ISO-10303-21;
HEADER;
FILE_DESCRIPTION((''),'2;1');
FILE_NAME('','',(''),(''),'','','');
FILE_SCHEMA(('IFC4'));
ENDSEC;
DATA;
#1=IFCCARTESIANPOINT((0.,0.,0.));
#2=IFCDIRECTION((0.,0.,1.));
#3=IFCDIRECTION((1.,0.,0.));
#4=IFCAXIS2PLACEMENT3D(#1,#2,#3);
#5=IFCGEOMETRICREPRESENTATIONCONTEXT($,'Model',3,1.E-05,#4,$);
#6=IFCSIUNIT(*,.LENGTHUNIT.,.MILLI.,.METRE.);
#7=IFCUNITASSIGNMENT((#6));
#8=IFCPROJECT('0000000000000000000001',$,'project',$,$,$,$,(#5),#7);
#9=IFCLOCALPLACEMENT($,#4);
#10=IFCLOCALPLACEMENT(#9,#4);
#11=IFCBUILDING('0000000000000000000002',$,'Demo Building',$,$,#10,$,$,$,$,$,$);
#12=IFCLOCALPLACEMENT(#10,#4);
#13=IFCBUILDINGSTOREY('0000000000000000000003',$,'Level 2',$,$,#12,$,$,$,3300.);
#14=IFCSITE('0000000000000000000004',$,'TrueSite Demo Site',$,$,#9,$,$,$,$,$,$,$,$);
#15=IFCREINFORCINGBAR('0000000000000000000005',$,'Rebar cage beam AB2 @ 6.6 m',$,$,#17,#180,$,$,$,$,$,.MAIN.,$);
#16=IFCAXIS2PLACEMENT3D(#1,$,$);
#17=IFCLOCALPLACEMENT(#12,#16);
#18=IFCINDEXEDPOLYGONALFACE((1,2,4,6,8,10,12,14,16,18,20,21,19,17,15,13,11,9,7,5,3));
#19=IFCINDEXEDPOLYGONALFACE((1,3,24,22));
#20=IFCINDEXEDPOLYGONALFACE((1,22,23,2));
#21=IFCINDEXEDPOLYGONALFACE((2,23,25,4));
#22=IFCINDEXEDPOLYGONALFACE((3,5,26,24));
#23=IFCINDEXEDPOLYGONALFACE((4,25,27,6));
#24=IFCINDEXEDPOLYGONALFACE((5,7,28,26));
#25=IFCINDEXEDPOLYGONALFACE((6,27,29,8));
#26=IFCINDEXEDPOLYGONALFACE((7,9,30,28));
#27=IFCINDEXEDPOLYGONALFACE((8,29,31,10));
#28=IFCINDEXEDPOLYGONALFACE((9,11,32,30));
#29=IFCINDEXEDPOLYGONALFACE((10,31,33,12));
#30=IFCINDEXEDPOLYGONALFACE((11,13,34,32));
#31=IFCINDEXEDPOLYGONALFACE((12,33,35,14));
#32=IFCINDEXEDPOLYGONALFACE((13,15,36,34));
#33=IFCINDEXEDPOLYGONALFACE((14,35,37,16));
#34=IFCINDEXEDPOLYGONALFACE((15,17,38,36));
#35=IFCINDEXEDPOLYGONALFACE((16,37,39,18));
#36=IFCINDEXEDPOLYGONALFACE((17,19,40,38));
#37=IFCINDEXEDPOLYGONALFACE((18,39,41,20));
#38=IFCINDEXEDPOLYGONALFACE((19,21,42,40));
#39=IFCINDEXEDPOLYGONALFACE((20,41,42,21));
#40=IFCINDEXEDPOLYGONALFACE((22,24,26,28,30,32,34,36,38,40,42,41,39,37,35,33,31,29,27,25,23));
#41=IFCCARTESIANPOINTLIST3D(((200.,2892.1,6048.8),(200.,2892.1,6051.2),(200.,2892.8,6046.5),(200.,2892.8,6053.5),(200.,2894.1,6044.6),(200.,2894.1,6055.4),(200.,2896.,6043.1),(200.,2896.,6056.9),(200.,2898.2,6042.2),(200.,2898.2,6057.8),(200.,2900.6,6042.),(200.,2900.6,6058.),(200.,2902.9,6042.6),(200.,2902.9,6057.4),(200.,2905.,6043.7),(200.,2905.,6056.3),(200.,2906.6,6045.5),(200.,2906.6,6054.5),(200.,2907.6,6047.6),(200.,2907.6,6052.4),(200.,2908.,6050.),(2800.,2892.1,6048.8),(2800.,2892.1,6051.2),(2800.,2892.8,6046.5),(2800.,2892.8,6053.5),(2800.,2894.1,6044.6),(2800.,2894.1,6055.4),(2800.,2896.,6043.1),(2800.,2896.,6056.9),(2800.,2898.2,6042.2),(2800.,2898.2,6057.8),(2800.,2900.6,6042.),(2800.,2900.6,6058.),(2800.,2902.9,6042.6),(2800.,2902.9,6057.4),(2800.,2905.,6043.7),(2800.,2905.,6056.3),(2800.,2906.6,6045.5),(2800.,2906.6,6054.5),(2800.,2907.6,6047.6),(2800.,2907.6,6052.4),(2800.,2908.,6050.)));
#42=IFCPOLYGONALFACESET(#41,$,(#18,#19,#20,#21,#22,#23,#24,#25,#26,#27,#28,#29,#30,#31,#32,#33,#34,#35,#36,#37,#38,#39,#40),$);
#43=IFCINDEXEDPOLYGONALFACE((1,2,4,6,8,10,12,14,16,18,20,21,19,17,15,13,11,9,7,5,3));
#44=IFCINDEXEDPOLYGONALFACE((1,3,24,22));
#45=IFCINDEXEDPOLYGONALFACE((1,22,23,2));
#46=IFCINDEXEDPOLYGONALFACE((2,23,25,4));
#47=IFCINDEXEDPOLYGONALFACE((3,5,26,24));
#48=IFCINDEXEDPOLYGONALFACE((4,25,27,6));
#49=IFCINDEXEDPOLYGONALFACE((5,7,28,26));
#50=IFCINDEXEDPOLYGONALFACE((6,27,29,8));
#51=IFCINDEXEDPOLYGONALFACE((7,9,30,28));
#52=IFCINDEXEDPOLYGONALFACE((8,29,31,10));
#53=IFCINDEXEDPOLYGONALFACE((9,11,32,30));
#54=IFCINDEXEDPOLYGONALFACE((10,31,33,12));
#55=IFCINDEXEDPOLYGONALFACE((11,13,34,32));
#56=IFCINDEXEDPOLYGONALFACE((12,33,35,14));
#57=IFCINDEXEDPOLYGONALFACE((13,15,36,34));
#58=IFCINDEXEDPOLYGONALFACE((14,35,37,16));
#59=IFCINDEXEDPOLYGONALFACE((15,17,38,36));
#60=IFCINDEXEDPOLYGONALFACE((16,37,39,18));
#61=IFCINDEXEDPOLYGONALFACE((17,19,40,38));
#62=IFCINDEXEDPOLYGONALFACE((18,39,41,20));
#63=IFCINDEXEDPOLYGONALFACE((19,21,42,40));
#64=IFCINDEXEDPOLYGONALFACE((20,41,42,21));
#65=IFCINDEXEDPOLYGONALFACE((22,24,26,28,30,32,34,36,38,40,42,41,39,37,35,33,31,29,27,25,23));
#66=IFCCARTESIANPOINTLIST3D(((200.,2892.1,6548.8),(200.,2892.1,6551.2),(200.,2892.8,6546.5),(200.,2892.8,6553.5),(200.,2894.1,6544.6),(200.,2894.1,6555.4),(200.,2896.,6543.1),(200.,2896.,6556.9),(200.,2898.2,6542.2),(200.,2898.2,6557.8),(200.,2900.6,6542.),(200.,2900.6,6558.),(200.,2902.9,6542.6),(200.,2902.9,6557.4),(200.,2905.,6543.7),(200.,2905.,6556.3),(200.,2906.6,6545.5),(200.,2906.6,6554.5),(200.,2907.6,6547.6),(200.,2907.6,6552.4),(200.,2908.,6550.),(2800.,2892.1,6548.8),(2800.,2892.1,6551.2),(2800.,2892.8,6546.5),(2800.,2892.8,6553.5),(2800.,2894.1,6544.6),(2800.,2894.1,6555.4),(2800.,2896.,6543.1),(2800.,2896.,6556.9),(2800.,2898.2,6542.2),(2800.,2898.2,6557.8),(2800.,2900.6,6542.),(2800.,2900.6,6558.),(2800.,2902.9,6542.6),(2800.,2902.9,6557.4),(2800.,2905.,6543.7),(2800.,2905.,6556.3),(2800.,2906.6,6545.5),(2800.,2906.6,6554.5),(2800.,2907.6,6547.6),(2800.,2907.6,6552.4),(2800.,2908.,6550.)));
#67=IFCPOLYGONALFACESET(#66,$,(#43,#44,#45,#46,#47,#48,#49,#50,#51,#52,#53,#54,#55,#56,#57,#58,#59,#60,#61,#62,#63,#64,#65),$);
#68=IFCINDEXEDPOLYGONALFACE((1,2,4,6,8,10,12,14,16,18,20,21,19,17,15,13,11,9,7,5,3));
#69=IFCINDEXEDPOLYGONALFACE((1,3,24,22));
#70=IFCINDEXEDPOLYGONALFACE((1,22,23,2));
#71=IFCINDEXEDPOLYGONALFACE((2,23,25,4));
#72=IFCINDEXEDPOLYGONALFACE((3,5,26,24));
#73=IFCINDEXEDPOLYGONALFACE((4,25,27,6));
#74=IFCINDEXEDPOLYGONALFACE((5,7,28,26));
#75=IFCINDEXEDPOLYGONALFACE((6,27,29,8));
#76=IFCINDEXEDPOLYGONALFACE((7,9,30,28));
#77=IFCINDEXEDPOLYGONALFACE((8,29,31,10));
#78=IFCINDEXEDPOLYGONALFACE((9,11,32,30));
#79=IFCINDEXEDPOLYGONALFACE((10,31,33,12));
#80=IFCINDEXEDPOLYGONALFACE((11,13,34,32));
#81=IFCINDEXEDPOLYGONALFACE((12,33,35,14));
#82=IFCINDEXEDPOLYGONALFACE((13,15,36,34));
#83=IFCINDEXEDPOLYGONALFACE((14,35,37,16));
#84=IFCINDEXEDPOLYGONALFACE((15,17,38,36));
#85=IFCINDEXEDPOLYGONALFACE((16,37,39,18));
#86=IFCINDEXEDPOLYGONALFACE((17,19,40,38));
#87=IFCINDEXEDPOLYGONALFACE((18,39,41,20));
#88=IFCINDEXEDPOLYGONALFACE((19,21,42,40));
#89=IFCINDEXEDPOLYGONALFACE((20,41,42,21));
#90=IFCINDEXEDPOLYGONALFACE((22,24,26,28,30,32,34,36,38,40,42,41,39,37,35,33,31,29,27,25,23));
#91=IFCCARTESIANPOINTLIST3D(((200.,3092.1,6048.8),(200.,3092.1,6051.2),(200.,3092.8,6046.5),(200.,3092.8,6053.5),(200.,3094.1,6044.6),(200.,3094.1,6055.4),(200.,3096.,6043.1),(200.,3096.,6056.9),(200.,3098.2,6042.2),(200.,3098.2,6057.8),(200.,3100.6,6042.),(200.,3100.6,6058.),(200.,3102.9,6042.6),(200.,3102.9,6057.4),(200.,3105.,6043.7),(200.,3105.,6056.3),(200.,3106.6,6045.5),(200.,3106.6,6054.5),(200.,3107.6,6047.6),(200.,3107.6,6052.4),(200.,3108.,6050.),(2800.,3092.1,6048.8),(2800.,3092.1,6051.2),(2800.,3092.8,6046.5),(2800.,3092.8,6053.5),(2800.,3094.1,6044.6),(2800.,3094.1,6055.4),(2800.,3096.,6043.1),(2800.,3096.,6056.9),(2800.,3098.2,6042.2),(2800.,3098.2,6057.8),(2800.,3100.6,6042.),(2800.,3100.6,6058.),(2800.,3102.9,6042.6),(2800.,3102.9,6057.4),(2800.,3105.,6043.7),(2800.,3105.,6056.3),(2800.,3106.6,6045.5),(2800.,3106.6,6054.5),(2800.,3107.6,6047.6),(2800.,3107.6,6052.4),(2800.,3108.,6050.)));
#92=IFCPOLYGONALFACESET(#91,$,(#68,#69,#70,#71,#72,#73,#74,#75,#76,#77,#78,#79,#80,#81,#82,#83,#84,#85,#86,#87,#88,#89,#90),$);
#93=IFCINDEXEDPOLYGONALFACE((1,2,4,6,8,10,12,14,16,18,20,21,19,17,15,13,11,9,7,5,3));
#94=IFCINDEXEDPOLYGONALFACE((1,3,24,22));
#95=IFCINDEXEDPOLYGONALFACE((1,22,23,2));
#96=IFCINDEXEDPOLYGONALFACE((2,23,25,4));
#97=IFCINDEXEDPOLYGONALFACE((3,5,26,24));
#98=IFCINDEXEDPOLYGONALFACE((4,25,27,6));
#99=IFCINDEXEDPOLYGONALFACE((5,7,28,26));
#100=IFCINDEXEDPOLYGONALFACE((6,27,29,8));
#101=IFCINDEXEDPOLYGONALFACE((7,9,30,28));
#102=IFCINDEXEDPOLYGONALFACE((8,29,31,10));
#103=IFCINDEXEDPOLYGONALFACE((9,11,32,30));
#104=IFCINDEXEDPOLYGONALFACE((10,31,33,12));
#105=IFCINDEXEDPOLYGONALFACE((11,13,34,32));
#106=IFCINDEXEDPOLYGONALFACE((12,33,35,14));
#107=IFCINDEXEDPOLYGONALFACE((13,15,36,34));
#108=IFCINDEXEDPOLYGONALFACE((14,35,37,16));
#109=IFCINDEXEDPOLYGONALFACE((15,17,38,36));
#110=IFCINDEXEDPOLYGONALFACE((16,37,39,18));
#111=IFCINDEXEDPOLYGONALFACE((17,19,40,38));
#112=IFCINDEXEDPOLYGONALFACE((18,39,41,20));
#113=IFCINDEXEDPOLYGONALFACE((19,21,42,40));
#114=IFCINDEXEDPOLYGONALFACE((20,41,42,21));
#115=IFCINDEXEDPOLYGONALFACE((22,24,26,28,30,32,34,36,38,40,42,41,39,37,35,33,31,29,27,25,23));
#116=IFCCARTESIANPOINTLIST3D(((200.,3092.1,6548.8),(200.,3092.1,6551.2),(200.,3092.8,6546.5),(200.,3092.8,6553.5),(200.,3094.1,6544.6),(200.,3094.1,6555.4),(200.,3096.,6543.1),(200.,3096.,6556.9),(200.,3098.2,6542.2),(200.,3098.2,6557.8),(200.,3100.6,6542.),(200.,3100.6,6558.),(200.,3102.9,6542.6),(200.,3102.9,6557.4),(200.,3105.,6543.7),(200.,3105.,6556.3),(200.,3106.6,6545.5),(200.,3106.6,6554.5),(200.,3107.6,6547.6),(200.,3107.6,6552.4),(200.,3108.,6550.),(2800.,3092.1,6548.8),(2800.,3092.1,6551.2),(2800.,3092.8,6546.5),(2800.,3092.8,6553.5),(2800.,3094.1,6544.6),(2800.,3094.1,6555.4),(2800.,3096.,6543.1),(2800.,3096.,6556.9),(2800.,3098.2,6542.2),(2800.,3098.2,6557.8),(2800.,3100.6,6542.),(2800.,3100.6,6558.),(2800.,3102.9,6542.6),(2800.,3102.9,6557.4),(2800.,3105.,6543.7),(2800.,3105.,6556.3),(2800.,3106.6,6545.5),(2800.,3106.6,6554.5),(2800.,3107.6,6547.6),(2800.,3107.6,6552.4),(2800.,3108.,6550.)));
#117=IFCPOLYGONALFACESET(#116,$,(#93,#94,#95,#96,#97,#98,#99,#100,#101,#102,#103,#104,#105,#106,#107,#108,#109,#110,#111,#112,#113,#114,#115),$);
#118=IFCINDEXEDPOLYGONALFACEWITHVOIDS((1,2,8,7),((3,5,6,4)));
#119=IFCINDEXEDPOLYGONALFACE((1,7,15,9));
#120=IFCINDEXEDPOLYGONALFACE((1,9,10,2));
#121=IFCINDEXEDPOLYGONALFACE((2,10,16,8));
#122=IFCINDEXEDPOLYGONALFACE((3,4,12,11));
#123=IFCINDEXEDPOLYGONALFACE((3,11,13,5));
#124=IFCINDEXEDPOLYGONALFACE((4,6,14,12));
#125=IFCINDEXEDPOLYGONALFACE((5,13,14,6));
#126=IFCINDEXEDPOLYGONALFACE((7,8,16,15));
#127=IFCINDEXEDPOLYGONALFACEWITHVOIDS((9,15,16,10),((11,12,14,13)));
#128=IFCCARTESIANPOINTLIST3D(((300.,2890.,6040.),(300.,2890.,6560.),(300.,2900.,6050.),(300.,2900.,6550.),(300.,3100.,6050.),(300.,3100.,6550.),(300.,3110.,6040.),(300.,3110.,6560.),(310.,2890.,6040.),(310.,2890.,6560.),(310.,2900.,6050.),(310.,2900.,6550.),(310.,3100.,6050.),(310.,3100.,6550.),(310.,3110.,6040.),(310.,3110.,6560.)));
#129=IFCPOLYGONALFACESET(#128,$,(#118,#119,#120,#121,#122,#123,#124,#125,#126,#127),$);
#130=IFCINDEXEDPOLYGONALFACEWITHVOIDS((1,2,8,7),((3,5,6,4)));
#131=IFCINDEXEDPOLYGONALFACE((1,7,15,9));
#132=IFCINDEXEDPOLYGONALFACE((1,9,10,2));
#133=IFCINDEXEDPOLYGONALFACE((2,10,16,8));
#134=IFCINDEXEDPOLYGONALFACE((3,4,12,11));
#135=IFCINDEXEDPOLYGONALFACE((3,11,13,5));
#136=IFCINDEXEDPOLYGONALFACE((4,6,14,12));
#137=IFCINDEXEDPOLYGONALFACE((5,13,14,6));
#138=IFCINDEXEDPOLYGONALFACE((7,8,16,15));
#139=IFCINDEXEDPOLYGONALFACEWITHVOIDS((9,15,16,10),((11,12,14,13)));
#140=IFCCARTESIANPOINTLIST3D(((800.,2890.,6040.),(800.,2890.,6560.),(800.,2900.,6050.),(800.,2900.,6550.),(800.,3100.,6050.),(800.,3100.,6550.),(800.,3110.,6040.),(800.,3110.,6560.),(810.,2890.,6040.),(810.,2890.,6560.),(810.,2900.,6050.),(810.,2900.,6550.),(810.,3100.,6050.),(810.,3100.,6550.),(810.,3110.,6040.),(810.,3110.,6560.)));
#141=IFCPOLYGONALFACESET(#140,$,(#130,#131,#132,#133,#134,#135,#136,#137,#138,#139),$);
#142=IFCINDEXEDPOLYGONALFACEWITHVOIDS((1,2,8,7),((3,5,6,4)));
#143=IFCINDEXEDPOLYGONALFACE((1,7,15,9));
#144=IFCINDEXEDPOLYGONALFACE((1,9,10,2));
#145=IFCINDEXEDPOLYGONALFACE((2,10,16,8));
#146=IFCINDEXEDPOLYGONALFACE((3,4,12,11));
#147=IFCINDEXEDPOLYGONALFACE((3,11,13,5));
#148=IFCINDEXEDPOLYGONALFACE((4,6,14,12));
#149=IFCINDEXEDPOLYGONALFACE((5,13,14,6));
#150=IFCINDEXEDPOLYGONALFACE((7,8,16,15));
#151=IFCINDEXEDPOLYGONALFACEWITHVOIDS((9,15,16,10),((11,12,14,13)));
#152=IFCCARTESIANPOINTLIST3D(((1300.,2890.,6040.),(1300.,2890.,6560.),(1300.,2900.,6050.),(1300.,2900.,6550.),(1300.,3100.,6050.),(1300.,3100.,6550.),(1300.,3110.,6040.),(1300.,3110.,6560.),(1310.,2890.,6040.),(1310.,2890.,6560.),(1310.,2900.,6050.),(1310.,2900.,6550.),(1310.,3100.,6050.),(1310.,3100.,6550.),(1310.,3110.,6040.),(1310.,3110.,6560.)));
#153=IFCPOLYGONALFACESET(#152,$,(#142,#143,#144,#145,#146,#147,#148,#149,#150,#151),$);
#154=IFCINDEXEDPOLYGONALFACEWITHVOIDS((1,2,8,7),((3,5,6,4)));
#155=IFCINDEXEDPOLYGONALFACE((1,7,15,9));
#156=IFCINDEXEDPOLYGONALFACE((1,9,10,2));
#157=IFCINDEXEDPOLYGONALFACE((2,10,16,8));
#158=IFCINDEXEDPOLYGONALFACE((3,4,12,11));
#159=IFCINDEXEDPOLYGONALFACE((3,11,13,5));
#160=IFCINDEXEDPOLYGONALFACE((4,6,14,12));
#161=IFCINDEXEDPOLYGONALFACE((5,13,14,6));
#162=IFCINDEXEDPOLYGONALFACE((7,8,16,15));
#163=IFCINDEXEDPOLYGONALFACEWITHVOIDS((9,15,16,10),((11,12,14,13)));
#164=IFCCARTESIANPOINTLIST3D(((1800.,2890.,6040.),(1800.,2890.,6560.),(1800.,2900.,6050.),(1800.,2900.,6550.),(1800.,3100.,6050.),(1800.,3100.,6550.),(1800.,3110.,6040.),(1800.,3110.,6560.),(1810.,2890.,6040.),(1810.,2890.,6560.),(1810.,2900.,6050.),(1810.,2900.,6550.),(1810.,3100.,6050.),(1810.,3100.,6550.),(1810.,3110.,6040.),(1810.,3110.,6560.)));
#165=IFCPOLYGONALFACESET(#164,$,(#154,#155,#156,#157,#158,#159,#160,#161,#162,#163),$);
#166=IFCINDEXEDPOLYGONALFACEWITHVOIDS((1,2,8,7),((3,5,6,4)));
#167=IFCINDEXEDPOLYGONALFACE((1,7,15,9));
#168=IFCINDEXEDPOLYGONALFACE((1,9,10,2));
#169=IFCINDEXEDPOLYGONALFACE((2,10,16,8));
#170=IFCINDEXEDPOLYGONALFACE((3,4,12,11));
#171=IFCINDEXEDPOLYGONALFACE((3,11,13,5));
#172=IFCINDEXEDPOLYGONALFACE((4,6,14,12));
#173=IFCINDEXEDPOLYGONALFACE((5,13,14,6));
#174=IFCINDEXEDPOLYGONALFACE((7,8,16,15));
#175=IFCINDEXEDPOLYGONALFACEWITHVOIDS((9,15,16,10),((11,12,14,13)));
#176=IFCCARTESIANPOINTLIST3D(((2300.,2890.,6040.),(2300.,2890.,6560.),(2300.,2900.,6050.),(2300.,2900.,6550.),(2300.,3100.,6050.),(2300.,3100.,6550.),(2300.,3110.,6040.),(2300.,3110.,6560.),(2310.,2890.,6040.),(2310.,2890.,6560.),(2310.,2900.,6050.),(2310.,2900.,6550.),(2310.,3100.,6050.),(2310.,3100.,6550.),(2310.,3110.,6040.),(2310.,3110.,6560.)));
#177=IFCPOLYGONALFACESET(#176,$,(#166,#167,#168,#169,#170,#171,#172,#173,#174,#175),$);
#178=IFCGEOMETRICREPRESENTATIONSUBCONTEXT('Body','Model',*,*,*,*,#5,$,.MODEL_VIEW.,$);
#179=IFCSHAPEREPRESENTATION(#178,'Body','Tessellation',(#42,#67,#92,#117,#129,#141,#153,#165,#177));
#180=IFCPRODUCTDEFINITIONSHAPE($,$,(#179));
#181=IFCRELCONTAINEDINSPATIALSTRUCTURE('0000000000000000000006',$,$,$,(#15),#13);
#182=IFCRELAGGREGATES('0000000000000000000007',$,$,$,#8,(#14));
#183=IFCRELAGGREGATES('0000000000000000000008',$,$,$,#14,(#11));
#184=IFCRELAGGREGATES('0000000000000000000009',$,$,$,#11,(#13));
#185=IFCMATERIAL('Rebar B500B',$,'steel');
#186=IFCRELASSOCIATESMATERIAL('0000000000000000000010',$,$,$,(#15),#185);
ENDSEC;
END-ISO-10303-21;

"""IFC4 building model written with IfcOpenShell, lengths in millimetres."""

from ifc_helpers import new_model, si_unit, frame, origin_with_axes, place, context, subcontext, project, spatial, hollow_rectangle, circle, extrude, material, element, save


model = new_model("IFC4")

# Units and contexts
model_context = context("Model", 3, precision=1e-05, world=origin_with_axes())
body_context = subcontext(model_context, "Body", "Model", "MODEL_VIEW")
ifc_project = project(units=[si_unit("LENGTHUNIT", "METRE", prefix="MILLI")], contexts=[model_context])

# Site, building, storey
site_placement = place(None, origin_with_axes())
site = spatial("IfcSite", under=ifc_project, at=site_placement, Name="TrueSite Demo Site")
building_placement = place(site_placement, origin_with_axes())
building = spatial("IfcBuilding", under=site, at=building_placement, Name="Demo Building")
storey_placement = place(building_placement, origin_with_axes())
storey = spatial("IfcBuildingStorey", under=building, at=storey_placement, Name="Level 2", Elevation=3300.0)

# Reinforcing bar
ifc_material_1 = material(Name="Rebar B500B", Category="steel")
for number, where, z_axis, x_axis, name in (
    (1, (200.0, 3000.0, 6300.0), (1.0, 0.0, 0.0), (0.0, 1.0, 0.0), "Rebar cage beam AB2 @ 6.6 m"),
):
    element("IfcReinforcingBar", number, at=place(storey_placement, frame(where, z_axis=z_axis, x_axis=x_axis)), inside=storey, material=ifc_material_1, Name=name, PredefinedType="MAIN", context=body_context, shape_type="SweptSolid", body=[
        extrude(circle(Radius=8.0), frame((-100.0, -250.0, 0.0)), (0.0, 0.0, 1.0), 2600.0),
        extrude(circle(Radius=8.0), frame((-100.0, 250.0, 0.0)), (0.0, 0.0, 1.0), 2600.0),
        extrude(circle(Radius=8.0), frame((100.0, -250.0, 0.0)), (0.0, 0.0, 1.0), 2600.0),
        extrude(circle(Radius=8.0), frame((100.0, 250.0, 0.0)), (0.0, 0.0, 1.0), 2600.0),
        extrude(hollow_rectangle(XDim=220.0, YDim=520.0, WallThickness=10.0), frame((0.0, 0.0, 100.0)), (0.0, 0.0, 1.0), 10.0),
        extrude(hollow_rectangle(XDim=220.0, YDim=520.0, WallThickness=10.0), frame((0.0, 0.0, 600.0)), (0.0, 0.0, 1.0), 10.0),
        extrude(hollow_rectangle(XDim=220.0, YDim=520.0, WallThickness=10.0), frame((0.0, 0.0, 1100.0)), (0.0, 0.0, 1.0), 10.0),
        extrude(hollow_rectangle(XDim=220.0, YDim=520.0, WallThickness=10.0), frame((0.0, 0.0, 1600.0)), (0.0, 0.0, 1.0), 10.0),
        extrude(hollow_rectangle(XDim=220.0, YDim=520.0, WallThickness=10.0), frame((0.0, 0.0, 2100.0)), (0.0, 0.0, 1.0), 10.0),
    ])

save(model, "model.ifc")
